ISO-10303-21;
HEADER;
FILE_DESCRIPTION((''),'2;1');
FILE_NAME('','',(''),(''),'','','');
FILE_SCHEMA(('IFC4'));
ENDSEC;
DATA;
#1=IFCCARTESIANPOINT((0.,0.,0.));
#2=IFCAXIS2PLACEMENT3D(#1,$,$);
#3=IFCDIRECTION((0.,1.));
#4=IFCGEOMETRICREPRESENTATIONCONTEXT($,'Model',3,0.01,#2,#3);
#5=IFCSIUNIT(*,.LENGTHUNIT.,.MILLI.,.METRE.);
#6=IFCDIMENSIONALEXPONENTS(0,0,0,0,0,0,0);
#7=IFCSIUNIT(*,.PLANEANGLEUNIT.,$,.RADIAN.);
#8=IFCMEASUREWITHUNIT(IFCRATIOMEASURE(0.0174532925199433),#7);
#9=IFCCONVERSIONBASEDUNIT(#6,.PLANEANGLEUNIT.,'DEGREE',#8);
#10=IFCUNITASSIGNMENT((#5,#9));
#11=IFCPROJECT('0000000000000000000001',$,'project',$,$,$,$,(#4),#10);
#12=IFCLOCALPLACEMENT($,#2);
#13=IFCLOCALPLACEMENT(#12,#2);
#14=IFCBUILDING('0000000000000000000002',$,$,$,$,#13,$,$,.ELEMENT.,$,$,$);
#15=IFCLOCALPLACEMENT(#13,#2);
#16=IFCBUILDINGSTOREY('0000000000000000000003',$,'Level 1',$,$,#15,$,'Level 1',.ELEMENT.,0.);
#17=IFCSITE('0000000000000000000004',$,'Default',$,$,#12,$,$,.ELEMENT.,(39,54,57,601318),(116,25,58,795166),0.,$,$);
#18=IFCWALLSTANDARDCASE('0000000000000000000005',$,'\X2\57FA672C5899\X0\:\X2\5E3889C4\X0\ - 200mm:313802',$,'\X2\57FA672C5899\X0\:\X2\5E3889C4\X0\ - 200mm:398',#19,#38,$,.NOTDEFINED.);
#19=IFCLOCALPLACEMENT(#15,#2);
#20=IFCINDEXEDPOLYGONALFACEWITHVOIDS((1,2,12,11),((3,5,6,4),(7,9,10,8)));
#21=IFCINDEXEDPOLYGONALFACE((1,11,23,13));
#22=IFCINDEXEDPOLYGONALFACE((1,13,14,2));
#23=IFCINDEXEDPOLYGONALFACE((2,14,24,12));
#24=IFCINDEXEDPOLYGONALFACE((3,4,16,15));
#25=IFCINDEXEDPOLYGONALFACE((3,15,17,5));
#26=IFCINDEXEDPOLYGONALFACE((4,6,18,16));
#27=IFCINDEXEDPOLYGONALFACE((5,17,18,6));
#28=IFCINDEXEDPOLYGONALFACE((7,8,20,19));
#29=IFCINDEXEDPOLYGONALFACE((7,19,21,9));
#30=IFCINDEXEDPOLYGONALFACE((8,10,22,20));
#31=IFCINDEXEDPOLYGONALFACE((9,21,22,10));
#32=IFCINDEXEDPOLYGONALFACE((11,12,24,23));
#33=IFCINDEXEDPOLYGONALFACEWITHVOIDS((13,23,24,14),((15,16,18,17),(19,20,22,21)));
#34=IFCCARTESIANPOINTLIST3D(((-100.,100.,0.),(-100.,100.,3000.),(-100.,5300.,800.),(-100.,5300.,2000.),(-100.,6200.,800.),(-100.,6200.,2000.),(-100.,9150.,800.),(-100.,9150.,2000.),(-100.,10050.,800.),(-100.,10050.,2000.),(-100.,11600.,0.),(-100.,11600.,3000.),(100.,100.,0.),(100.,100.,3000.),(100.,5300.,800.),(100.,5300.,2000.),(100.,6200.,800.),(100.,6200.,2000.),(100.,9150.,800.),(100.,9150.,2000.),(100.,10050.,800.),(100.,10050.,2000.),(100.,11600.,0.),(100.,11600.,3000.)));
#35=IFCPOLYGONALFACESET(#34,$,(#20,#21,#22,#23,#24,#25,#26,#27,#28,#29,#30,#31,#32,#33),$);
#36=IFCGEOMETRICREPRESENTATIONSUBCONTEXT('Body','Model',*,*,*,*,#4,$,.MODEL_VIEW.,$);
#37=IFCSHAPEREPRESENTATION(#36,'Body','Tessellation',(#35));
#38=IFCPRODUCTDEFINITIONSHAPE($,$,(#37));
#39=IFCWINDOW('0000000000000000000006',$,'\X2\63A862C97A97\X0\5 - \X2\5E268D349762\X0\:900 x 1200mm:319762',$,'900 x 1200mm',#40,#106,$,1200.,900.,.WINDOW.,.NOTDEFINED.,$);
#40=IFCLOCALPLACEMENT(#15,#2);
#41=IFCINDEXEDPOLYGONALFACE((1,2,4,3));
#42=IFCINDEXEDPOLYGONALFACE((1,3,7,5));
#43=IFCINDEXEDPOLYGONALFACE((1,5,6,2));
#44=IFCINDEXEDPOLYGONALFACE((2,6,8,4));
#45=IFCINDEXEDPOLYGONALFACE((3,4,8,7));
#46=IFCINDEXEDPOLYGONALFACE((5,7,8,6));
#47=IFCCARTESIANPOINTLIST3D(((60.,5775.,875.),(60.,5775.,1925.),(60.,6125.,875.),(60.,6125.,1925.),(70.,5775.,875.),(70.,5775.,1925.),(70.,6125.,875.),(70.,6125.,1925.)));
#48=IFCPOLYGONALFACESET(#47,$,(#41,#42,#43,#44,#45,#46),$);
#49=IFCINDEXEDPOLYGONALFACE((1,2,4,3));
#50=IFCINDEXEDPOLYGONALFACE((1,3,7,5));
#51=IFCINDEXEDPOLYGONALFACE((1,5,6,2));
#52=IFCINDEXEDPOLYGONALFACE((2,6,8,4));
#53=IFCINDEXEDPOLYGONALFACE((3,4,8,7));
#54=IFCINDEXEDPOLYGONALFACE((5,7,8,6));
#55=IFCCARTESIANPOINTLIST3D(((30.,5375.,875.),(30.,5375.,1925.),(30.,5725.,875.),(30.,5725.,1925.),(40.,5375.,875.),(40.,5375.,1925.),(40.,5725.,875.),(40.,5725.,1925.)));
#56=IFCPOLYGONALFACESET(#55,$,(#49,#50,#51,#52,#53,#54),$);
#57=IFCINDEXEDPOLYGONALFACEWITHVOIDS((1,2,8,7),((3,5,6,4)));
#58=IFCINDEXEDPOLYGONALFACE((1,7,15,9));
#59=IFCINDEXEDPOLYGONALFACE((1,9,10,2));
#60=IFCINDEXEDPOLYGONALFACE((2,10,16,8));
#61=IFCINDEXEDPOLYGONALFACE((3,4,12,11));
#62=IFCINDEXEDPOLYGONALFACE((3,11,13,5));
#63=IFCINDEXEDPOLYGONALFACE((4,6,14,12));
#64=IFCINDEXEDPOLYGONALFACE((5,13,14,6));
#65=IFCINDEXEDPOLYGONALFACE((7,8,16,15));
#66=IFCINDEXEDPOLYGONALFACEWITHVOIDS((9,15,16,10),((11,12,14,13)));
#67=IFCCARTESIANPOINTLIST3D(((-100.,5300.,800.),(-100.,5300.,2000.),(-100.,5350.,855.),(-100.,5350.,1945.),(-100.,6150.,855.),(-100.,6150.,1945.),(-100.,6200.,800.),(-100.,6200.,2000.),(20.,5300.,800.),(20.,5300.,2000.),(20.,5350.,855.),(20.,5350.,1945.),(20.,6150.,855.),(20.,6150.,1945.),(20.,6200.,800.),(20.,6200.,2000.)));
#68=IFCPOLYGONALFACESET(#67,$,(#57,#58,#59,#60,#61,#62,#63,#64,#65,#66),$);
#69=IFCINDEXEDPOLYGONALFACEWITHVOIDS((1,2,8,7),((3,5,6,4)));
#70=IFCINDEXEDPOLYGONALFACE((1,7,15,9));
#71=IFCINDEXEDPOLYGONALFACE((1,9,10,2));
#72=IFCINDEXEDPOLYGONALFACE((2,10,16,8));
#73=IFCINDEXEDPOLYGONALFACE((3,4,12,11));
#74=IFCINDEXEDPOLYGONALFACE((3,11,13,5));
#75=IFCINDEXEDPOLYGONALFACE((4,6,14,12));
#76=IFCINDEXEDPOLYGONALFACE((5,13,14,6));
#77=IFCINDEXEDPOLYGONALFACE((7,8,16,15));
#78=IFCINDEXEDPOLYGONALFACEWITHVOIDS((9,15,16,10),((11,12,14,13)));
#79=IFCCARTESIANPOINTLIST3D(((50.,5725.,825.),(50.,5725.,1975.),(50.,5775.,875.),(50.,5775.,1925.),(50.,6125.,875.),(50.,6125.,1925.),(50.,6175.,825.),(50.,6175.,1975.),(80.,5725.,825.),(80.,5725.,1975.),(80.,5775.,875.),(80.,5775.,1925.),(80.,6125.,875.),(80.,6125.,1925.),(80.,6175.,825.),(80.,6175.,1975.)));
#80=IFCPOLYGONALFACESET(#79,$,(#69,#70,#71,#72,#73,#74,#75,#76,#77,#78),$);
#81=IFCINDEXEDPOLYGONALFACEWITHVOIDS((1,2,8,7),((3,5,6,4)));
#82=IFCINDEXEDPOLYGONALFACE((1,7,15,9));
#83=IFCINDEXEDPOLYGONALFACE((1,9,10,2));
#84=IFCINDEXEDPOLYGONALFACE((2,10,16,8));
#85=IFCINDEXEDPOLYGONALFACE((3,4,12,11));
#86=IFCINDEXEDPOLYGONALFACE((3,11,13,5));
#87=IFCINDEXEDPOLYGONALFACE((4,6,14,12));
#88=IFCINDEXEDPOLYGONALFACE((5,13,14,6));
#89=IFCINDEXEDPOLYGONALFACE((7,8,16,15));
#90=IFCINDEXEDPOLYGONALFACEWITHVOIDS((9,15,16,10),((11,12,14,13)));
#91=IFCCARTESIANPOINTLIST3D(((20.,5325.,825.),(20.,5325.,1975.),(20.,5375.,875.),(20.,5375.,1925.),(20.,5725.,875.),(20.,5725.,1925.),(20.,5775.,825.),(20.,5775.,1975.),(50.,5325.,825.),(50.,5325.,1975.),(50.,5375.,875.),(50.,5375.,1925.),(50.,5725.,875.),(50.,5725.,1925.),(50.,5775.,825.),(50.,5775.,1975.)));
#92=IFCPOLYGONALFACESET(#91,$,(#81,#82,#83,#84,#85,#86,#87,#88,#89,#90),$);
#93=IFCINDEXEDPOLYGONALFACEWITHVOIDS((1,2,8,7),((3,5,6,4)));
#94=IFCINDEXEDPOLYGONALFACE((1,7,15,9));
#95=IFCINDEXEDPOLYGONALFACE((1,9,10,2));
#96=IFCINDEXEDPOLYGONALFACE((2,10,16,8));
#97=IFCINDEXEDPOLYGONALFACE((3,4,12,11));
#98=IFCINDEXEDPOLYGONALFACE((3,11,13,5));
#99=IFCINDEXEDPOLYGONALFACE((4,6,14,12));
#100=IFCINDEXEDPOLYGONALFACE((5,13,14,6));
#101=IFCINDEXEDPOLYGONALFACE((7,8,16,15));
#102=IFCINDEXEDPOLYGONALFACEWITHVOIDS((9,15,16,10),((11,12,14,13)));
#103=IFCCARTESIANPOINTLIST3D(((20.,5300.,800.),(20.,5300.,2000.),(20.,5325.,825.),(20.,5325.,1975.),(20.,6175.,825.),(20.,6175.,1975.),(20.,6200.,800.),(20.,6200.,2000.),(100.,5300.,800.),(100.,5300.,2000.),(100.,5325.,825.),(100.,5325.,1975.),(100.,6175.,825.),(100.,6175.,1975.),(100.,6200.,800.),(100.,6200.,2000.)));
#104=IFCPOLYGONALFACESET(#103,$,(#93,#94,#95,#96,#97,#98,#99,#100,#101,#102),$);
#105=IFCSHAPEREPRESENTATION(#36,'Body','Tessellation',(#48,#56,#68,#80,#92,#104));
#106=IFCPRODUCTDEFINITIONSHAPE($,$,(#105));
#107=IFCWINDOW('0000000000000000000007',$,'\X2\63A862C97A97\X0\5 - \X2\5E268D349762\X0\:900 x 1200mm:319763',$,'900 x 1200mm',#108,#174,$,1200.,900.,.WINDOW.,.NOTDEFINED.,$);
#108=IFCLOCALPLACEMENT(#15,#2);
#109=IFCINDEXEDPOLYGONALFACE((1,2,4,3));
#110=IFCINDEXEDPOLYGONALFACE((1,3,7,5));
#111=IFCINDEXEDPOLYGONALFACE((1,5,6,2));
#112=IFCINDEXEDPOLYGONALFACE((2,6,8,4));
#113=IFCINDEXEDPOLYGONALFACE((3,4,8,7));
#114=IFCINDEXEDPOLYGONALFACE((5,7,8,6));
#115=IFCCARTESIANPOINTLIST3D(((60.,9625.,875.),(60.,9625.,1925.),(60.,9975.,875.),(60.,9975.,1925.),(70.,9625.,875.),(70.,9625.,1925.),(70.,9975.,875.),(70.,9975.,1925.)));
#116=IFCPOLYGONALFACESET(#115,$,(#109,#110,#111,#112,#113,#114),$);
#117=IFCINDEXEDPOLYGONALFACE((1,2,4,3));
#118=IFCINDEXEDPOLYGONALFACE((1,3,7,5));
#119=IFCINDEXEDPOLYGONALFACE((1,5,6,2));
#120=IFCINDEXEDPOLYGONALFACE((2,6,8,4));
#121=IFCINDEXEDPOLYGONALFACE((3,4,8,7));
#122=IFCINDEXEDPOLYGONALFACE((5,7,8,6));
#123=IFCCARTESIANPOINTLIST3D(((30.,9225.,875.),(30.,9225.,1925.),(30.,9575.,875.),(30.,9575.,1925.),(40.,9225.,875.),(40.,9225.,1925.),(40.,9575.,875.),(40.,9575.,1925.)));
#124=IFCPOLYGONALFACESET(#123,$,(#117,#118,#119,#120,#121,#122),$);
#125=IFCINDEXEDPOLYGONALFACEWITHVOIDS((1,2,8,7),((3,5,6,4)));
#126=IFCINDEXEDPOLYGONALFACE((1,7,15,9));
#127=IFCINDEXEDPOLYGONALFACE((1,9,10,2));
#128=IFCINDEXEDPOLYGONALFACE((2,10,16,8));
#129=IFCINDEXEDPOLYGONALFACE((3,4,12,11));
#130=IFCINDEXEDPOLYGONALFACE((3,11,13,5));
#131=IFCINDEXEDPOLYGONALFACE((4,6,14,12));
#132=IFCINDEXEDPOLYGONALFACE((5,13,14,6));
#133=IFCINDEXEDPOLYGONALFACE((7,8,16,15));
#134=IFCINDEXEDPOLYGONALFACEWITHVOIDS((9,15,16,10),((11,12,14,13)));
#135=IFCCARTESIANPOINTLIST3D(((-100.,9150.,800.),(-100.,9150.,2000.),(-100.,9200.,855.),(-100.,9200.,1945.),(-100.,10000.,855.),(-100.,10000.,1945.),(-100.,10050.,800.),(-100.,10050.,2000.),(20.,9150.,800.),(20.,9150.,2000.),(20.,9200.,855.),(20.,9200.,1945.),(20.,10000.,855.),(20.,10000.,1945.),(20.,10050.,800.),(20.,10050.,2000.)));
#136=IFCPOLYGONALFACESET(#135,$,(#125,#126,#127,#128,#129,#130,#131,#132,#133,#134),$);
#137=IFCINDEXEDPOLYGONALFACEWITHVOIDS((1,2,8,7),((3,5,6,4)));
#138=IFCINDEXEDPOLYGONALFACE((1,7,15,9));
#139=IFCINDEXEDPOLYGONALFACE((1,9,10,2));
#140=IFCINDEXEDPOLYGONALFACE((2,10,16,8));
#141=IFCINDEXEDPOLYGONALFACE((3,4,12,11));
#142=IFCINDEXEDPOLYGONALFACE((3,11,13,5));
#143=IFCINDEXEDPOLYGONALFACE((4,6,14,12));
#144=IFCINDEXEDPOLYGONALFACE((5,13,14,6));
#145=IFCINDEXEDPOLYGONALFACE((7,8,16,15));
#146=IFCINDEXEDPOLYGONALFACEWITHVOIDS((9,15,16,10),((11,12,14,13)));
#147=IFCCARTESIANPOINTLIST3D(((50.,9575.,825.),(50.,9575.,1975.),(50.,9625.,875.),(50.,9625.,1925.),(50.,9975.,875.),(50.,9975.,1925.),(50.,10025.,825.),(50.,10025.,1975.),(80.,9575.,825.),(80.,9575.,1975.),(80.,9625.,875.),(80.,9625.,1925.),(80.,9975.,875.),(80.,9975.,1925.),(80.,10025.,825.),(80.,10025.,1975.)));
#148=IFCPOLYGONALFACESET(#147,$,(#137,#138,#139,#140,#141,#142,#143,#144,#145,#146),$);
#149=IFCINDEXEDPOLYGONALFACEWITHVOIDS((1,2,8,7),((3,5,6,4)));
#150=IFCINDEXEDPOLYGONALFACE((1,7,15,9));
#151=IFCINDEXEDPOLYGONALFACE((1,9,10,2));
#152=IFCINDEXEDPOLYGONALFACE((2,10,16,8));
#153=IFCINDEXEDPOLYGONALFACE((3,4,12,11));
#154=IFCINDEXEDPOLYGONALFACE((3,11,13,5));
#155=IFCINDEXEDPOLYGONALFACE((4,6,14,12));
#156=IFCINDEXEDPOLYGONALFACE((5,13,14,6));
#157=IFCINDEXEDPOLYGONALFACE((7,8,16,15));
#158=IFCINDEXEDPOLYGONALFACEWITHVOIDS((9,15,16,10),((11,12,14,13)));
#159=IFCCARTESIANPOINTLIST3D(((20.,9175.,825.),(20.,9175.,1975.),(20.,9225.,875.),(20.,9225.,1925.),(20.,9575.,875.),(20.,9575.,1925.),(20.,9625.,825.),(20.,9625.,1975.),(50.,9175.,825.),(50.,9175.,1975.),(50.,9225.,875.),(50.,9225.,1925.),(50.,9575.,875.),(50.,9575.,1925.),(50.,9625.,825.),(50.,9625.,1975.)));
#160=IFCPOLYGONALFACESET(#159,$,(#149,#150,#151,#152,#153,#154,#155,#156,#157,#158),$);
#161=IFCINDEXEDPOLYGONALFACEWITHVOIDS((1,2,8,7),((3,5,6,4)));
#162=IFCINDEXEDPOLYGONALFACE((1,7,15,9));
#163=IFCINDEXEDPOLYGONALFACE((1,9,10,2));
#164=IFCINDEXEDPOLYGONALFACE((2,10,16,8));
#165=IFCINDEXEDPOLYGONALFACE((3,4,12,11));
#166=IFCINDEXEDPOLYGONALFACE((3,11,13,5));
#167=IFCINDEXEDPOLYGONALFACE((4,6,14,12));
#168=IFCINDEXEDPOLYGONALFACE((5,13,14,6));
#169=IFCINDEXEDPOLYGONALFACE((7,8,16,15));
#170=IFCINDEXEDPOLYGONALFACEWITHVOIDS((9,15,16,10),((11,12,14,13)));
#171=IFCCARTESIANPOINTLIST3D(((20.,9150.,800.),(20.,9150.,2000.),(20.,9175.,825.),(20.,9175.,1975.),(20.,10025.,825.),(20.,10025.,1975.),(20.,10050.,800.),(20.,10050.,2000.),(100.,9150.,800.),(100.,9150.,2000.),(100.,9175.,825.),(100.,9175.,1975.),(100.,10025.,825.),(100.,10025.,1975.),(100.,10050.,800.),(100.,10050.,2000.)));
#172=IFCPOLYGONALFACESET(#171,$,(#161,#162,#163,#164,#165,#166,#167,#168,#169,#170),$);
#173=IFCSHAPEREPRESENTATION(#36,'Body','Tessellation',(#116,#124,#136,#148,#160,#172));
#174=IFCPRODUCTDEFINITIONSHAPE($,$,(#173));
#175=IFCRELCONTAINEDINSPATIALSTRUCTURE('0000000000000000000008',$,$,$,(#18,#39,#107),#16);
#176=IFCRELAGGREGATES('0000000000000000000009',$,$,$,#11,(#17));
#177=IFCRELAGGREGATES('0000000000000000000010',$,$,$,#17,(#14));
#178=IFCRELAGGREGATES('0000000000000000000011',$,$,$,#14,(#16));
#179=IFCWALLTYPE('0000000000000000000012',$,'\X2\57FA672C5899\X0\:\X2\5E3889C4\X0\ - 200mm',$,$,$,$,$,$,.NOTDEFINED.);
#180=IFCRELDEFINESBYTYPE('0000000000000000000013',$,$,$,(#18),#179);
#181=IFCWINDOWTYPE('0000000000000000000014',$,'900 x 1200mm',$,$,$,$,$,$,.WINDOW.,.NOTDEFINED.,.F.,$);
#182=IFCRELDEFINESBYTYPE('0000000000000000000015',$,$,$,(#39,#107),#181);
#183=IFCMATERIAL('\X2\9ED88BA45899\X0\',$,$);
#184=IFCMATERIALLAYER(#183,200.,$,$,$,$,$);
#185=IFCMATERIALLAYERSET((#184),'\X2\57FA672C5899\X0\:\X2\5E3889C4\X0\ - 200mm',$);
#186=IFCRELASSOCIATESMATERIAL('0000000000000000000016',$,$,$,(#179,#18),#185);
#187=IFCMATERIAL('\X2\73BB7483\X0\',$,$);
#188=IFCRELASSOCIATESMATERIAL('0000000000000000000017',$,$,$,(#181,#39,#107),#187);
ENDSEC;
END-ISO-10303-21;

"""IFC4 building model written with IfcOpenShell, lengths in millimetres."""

from ifc_helpers import new_model, entity, si_unit, converted_unit, direction, frame, frame_2d, origin, origin_2d_with_axis, place, context, subcontext, project, spatial, polyline, rectangle, outline, extrude, source, transform, mapped, material, layer, layer_set, layer_usage, type_object, type_shapes, element, fill, save


model = new_model("IFC4")

# Units and contexts
model_context = context("Model", 3, precision=0.01, world=origin(), true_north=direction((0.0, 1.0)))
body_context = subcontext(model_context, "Body", "Model", "MODEL_VIEW")
ifc_project = project(units=[si_unit("LENGTHUNIT", "METRE", prefix="MILLI"), converted_unit("PLANEANGLEUNIT", "DEGREE", entity("IfcRatioMeasure", 0.0174532925199433), si_unit("PLANEANGLEUNIT", "RADIAN"), dimensions=[0, 0, 0, 0, 0, 0, 0])], contexts=[model_context])

# Site, building, storey
site_placement = place(None, origin())
site = spatial("IfcSite", under=ifc_project, at=site_placement, Name="Default", CompositionType="ELEMENT", RefLatitude=(39, 54, 57, 601318), RefLongitude=(116, 25, 58, 795166), RefElevation=0.0)
building_placement = place(site_placement, origin())
building = spatial("IfcBuilding", under=site, at=building_placement, CompositionType="ELEMENT")
storey_placement = place(building_placement, origin())
storey = spatial("IfcBuildingStorey", under=building, at=storey_placement, Name="Level 1", LongName="Level 1", CompositionType="ELEMENT", Elevation=0.0)

# Shared definitions
ifc_material_1 = material(Name="默认墙")
ifc_layer = layer(ifc_material_1, 200.0)
ifc_layer_set = layer_set([ifc_layer], Name="基本墙:常规 - 200mm")
wall_type = type_object("IfcWallType", Name="基本墙:常规 - 200mm", PredefinedType="NOTDEFINED", material=ifc_layer_set)
ifc_material_2 = material(Name="玻璃")

# Wall, openings, windows
ifc_layer_usage_1 = layer_usage(ifc_layer_set, "AXIS2", "NEGATIVE", 100.0)
wall_1_placement = place(storey_placement, frame((0.0, 100.0, 0.0), z_axis=(0.0, 0.0, 1.0), x_axis=(0.0, 1.0, 0.0)))
wall_1 = element("IfcWallStandardCase", 1, at=wall_1_placement, inside=storey, type_object=wall_type, material=ifc_layer_usage_1, Name="基本墙:常规 - 200mm:313802", ObjectType="基本墙:常规 - 200mm:398", PredefinedType="NOTDEFINED", context=body_context, shape_type="SweptSolid", body=[
    extrude(rectangle(XDim=11500.0, YDim=200.0, at=frame_2d((5750.0, 0.0), x_axis=(-1.0, 0.0))), origin(), (0.0, 0.0, 1.0), 3000.0),
])
opening_1_placement = place(wall_1_placement, frame((6100.0, 100.0, 800.0)))
opening_1 = element("IfcOpeningElement", 2, at=opening_1_placement, cuts=wall_1, ObjectType="Opening", PredefinedType="OPENING", context=body_context, shape_type="SweptSolid", body=[
    extrude(rectangle(XDim=1200.0, YDim=900.0, at=frame_2d((600.0, 450.0), x_axis=(-1.0, 0.0))), frame((0.0, 0.0, 0.0), z_axis=(0.0, -1.0, 0.0), x_axis=(0.0, 0.0, 1.0)), (0.0, 0.0, 1.0), 200.0),
])
opening_2_placement = place(wall_1_placement, frame((9950.0, 100.0, 800.0)))
opening_2 = element("IfcOpeningElement", 3, at=opening_2_placement, cuts=wall_1, ObjectType="Opening", PredefinedType="OPENING", context=body_context, shape_type="SweptSolid", body=[
    extrude(rectangle(XDim=1200.0, YDim=900.0, at=frame_2d((600.0, 450.0), x_axis=(-1.0, 0.0))), frame((0.0, 0.0, 0.0), z_axis=(0.0, -1.0, 0.0), x_axis=(0.0, 0.0, 1.0)), (0.0, 0.0, 1.0), 200.0),
])
window_type_1 = type_object("IfcWindowType", Name="900 x 1200mm", ParameterTakesPrecedence=False, PartitioningType="NOTDEFINED", PredefinedType="WINDOW", material=ifc_material_2)
shared_shape_1 = source(origin(), body_context, "Body", "SweptSolid", [
    extrude(rectangle(XDim=10.0, YDim=350.0, at=origin_2d_with_axis()), frame((250.0, 165.0, 75.0), z_axis=(0.0, 0.0, 1.0), x_axis=(0.0, -1.0, 0.0)), (0.0, 0.0, 1.0), 1050.0),
    extrude(rectangle(XDim=10.0, YDim=350.0, at=frame_2d((0.0, 0.0), x_axis=(1.0, 0.0))), frame((650.0, 135.0, 75.0), z_axis=(0.0, 0.0, 1.0), x_axis=(0.0, -1.0, 0.0)), (0.0, 0.0, 1.0), 1050.0),
    extrude(outline(polyline([(-450.0, -600.0), (450.0, -600.0), (450.0, 600.0), (-450.0, 600.0), (-450.0, -600.0)]), holes=[polyline([(400.0, -545.0), (-400.0, -545.0), (-400.0, 545.0), (400.0, 545.0), (400.0, -545.0)])]), frame((450.0, 0.0, 600.0), z_axis=(0.0, 1.0, 0.0), x_axis=(1.0, 0.0, 0.0)), (0.0, 0.0, 1.0), 120.0),
    extrude(outline(polyline([(-225.0, -575.0), (225.0, -575.0), (225.0, 575.0), (-225.0, 575.0), (-225.0, -575.0)]), holes=[polyline([(-175.0, -525.0), (-175.0, 525.0), (175.0, 525.0), (175.0, -525.0), (-175.0, -525.0)])]), frame((250.0, 150.0, 600.0), z_axis=(0.0, 1.0, 0.0), x_axis=(-1.0, 0.0, 0.0)), (0.0, 0.0, 1.0), 30.0),
    extrude(outline(polyline([(-225.0, -575.0), (225.0, -575.0), (225.0, 575.0), (-225.0, 575.0), (-225.0, -575.0)]), holes=[polyline([(-175.0, -525.0), (-175.0, 525.0), (175.0, 525.0), (175.0, -525.0), (-175.0, -525.0)])]), frame((650.0, 120.0, 600.0), z_axis=(0.0, 1.0, 0.0), x_axis=(1.0, 0.0, 0.0)), (0.0, 0.0, 1.0), 30.0),
    extrude(outline(polyline([(-450.0, -600.0), (450.0, -600.0), (450.0, 600.0), (-450.0, 600.0), (-450.0, -600.0)]), holes=[polyline([(-425.0, 575.0), (425.0, 575.0), (425.0, -575.0), (-425.0, -575.0), (-425.0, 575.0)])]), frame((450.0, 120.0, 600.0), z_axis=(0.0, 1.0, 0.0), x_axis=(1.0, 0.0, 0.0)), (0.0, 0.0, 1.0), 80.0),
])
type_shapes(window_type_1, [shared_shape_1])
window_1_placement = place(opening_1_placement, frame((0.0, 0.0, 0.0), z_axis=(0.0, 0.0, 1.0), x_axis=(-1.0, 0.0, 0.0)))
window_1 = element("IfcWindow", 4, at=window_1_placement, inside=storey, type_object=window_type_1, material=ifc_material_2, Name="推拉窗5 - 带贴面:900 x 1200mm:319762", ObjectType="900 x 1200mm", OverallHeight=1200.0, OverallWidth=900.0, PartitioningType="NOTDEFINED", PredefinedType="WINDOW", context=body_context, shape_type="MappedRepresentation", body=[
    mapped(shared_shape_1, transform((0.0, 0.0, 0.0), scale=1.0)),
])
fill(opening_1, window_1)
window_2_placement = place(opening_2_placement, frame((0.0, 0.0, 0.0), z_axis=(0.0, 0.0, 1.0), x_axis=(-1.0, 0.0, 0.0)))
window_2 = element("IfcWindow", 5, at=window_2_placement, inside=storey, type_object=window_type_1, material=ifc_material_2, Name="推拉窗5 - 带贴面:900 x 1200mm:319763", ObjectType="900 x 1200mm", OverallHeight=1200.0, OverallWidth=900.0, PartitioningType="NOTDEFINED", PredefinedType="WINDOW", context=body_context, shape_type="MappedRepresentation", body=[
    mapped(shared_shape_1, transform((0.0, 0.0, 0.0), scale=1.0)),
])
fill(opening_2, window_2)

save(model, "model.ifc")
